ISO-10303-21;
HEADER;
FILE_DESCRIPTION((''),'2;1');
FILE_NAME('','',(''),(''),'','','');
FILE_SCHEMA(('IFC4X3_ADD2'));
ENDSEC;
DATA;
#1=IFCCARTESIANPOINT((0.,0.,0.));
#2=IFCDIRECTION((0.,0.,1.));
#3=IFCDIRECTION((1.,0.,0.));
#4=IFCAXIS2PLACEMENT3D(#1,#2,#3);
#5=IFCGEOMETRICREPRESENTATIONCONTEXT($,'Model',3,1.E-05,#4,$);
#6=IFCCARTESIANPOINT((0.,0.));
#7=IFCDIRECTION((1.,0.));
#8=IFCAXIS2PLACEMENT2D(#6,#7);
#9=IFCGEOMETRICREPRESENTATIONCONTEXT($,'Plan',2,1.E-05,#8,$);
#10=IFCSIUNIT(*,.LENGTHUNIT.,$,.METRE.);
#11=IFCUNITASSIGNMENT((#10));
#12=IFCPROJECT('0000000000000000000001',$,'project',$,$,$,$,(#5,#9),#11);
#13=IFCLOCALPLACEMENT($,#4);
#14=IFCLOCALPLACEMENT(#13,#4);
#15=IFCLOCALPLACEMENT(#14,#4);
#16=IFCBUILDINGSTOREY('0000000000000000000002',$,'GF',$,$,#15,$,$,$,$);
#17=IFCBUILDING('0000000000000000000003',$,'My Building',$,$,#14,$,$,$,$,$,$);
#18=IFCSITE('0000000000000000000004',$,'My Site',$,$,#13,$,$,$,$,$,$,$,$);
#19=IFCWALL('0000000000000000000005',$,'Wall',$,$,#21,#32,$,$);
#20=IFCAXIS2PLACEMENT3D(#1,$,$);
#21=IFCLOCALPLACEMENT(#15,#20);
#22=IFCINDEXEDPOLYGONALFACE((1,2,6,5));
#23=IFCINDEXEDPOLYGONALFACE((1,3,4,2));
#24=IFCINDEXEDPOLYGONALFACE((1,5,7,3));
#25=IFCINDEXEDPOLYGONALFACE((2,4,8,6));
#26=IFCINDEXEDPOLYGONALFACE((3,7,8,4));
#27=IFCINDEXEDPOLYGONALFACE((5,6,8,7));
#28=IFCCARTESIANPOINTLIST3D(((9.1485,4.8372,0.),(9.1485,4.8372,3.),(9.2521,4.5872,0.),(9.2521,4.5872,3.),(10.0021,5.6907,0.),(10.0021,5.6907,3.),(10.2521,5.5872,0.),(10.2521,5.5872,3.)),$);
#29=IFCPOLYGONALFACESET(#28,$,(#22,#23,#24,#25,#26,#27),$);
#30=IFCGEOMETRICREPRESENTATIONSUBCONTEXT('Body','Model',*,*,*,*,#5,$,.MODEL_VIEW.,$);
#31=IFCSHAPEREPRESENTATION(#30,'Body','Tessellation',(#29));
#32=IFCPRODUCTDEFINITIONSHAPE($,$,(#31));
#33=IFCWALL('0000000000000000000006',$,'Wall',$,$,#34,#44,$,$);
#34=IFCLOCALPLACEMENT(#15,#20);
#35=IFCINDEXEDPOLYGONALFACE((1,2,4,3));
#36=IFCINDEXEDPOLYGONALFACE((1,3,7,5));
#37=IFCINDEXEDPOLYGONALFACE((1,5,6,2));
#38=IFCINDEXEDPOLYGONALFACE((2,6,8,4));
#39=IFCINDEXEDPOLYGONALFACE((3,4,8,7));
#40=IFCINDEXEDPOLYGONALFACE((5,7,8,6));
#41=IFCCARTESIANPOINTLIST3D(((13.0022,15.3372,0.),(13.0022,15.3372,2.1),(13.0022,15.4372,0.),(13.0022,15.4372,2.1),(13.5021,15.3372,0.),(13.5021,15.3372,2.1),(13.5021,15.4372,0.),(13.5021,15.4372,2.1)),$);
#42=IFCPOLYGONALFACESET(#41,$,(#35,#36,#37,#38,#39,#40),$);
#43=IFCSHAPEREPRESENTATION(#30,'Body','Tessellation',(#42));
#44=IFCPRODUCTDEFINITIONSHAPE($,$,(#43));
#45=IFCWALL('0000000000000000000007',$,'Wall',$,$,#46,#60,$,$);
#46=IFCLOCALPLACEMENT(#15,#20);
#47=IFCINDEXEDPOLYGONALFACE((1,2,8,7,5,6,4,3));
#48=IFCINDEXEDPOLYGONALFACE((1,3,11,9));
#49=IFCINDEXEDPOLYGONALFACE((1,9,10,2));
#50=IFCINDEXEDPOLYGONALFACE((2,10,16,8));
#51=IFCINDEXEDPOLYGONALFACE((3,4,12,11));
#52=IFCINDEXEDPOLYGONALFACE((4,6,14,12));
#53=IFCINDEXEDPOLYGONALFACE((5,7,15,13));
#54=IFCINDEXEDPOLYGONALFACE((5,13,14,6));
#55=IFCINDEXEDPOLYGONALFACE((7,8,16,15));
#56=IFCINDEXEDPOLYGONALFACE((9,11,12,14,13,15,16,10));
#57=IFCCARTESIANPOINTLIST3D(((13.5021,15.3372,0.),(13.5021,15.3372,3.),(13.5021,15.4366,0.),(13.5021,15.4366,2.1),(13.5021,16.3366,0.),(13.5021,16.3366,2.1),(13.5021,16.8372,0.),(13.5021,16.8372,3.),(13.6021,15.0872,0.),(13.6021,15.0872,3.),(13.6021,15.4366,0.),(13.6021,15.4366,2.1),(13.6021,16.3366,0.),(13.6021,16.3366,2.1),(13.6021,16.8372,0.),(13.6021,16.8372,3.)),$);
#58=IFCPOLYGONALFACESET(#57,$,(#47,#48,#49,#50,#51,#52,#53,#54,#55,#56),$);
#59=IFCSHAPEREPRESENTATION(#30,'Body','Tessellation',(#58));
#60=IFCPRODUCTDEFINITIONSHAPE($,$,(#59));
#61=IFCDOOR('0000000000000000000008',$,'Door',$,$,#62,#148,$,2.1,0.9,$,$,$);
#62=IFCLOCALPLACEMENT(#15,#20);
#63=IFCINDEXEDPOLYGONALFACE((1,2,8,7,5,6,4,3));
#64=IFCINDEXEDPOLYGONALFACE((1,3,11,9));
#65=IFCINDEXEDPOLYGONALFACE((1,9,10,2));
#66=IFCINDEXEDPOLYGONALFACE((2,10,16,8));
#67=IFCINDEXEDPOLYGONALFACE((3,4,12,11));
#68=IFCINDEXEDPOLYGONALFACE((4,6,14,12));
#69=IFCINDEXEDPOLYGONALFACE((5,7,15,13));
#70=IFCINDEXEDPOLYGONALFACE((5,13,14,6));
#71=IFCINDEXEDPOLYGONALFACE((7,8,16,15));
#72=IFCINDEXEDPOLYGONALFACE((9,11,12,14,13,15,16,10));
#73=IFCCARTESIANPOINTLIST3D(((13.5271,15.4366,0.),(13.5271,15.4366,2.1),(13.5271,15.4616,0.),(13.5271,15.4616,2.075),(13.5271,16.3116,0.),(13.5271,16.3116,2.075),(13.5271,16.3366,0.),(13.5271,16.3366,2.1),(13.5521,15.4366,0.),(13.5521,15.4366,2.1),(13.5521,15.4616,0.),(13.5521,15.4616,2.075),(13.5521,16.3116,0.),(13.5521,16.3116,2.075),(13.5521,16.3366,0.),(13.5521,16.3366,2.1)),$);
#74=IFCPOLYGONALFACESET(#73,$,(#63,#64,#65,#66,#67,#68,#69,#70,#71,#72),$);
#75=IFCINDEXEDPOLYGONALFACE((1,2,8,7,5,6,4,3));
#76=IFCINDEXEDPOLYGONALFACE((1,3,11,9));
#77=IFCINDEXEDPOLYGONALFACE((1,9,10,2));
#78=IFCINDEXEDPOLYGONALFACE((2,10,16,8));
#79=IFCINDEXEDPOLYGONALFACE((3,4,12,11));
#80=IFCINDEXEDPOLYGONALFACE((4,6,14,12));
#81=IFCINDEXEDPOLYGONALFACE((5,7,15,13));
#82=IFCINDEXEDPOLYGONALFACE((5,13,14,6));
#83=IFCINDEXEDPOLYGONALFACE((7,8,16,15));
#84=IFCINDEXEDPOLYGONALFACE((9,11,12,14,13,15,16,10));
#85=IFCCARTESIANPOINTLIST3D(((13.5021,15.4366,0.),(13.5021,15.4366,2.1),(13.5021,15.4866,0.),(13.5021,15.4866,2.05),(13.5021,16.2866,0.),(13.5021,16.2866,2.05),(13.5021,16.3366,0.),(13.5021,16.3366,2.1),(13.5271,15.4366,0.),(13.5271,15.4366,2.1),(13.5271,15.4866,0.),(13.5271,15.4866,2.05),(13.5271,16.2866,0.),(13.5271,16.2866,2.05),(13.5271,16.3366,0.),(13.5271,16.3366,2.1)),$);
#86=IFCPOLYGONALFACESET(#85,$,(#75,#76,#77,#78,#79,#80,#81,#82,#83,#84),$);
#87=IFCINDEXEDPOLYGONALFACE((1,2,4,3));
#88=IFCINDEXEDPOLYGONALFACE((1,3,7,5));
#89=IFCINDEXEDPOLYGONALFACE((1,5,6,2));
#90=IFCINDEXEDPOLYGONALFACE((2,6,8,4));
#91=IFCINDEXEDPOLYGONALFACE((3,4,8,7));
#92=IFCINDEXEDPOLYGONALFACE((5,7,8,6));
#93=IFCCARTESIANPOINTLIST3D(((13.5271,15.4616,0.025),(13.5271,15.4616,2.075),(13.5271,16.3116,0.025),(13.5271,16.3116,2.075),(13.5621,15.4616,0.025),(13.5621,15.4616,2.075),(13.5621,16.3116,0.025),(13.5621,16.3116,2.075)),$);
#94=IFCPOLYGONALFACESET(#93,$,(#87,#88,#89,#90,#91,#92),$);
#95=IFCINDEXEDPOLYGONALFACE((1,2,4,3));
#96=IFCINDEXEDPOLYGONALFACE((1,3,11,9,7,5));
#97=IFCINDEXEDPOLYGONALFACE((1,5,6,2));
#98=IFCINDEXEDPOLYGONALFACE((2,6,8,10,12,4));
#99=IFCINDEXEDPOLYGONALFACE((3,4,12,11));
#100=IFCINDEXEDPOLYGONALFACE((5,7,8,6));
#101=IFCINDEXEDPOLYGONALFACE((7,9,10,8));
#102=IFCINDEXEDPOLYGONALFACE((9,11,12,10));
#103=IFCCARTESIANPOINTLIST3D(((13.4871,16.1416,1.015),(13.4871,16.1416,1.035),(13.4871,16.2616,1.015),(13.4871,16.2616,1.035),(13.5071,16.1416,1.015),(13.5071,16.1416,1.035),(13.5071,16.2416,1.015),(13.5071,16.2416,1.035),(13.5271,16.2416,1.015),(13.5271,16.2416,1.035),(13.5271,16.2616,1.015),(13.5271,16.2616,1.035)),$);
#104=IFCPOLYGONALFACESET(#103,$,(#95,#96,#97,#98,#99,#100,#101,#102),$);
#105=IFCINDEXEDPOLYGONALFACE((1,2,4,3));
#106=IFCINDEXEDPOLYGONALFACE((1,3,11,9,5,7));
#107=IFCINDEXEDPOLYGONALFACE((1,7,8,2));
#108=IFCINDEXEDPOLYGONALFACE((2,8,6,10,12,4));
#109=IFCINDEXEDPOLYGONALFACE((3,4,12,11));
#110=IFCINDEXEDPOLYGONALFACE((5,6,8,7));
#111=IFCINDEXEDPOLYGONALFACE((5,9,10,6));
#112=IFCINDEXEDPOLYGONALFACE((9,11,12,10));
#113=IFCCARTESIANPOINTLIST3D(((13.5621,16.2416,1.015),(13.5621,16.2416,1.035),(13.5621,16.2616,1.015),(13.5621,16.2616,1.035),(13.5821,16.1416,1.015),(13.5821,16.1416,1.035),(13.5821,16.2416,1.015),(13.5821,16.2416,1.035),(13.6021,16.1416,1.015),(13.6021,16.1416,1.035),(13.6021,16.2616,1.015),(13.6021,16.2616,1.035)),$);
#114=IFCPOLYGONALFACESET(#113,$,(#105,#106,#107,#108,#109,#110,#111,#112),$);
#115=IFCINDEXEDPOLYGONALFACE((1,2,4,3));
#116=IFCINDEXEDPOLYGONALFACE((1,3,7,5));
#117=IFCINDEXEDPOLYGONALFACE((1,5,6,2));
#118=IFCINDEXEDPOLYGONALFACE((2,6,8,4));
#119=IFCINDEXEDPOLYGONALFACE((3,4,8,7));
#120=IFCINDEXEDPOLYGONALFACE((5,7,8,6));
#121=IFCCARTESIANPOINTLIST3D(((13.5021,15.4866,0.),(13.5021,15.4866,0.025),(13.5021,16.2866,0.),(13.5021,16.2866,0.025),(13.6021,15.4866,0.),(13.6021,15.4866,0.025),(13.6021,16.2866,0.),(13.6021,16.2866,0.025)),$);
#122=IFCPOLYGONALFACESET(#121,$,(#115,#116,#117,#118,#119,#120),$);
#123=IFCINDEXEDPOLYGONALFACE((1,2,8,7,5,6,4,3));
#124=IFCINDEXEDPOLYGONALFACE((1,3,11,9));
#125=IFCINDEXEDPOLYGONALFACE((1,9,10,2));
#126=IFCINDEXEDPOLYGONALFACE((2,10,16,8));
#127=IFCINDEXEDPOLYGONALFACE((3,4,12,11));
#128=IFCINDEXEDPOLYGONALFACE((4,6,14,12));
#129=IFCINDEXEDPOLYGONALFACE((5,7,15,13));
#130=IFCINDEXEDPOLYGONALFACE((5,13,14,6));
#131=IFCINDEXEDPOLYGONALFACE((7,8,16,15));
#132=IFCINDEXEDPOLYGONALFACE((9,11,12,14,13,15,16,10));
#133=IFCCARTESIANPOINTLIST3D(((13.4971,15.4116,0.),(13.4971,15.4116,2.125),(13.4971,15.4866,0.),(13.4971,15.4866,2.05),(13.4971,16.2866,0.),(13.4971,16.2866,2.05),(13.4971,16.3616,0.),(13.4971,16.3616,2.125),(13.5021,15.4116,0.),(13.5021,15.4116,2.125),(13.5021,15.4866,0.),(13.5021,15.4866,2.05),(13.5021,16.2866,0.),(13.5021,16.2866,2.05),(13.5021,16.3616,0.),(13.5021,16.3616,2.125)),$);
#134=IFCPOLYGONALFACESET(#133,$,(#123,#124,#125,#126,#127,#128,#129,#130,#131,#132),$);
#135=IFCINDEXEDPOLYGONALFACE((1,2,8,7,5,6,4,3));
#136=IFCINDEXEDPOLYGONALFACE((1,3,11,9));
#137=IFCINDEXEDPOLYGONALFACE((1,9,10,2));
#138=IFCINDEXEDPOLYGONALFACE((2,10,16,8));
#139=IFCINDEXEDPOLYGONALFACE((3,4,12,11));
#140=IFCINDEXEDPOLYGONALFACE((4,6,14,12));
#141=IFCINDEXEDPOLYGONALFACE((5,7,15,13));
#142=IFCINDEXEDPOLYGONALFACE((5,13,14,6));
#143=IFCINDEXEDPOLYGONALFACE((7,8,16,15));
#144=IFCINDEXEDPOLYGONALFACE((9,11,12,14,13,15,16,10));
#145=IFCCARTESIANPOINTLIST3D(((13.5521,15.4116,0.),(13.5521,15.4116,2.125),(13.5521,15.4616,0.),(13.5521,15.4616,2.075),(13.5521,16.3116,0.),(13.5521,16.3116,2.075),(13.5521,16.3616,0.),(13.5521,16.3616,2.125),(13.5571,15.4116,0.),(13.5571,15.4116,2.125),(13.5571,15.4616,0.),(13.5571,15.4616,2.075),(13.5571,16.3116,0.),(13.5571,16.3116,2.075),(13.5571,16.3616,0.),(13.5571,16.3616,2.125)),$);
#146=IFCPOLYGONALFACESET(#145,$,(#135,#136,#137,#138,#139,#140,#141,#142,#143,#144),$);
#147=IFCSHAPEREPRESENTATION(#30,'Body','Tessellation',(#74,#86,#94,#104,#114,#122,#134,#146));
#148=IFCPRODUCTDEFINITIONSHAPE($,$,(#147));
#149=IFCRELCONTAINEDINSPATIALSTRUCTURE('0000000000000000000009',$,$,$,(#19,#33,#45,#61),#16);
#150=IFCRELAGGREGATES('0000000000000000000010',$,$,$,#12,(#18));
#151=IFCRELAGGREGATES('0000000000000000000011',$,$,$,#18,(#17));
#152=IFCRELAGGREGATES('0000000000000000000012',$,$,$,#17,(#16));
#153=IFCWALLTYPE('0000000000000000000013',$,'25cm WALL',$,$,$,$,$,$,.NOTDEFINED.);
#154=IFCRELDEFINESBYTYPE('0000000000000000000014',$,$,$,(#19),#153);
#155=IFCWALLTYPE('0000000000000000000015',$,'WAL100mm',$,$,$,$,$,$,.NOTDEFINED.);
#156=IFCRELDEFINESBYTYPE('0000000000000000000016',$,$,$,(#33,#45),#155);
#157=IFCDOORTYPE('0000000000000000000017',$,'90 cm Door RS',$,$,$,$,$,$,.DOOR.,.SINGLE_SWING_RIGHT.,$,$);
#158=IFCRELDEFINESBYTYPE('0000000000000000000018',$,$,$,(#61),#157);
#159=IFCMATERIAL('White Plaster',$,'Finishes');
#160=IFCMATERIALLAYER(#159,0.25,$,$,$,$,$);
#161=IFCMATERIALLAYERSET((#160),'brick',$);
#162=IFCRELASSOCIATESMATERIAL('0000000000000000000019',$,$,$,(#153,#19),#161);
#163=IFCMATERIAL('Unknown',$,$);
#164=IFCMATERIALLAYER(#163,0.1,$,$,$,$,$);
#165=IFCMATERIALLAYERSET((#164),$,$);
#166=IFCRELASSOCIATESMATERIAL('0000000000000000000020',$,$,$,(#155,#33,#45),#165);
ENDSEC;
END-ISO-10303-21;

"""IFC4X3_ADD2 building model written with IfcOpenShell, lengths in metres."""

from ifc_helpers import new_model, entity, si_unit, frame, origin_with_axes, origin_2d_with_axis, place, context, subcontext, project, spatial, line, indexed_curve, outline, extrude, shape, source, transform, mapped, material, layer, layer_set, layer_usage, type_object, type_shapes, element, fill, save


model = new_model("IFC4X3_ADD2")

# Units and contexts
model_context = context("Model", 3, precision=1e-05, world=origin_with_axes())
plan_context = context("Plan", 2, precision=1e-05, world=origin_2d_with_axis())
body_context_1 = subcontext(model_context, "Body", "Model", "MODEL_VIEW")
body_context_2 = subcontext(plan_context, "Body", "Plan", "PLAN_VIEW")
ifc_project = project(units=[si_unit("LENGTHUNIT", "METRE")], contexts=[model_context, plan_context])

# Site, building, storey
site_placement = place(None, origin_with_axes())
site = spatial("IfcSite", under=ifc_project, at=site_placement, Name="My Site")
building_placement = place(site_placement, origin_with_axes())
building = spatial("IfcBuilding", under=site, at=building_placement, Name="My Building")
storey_placement = place(building_placement, origin_with_axes())
storey = spatial("IfcBuildingStorey", under=building, at=storey_placement, Name="GF")

# Shared definitions
ifc_material_1 = material(Name="White Plaster", Category="Finishes")

# Shared definitions
ifc_layer_1 = layer(ifc_material_1, 0.25)
ifc_layer_set_1 = layer_set([ifc_layer_1], Name="brick")
wall_type_1 = type_object("IfcWallType", Name="25cm WALL", PredefinedType="NOTDEFINED", material=ifc_layer_set_1)

# Walls
ifc_layer_usage_1 = layer_usage(ifc_layer_set_1, "AXIS2", "POSITIVE", 0.0)
wall_1_placement = place(storey_placement, frame((10.0021, 5.6907, 0.0), z_axis=(0.0, 0.0, 1.0), x_axis=(-0.707107, -0.707107, 0.0)))
element("IfcWall", 1, at=wall_1_placement, inside=storey, type_object=wall_type_1, material=ifc_layer_usage_1, Name="Wall", context=body_context_1, shape_type="SweptSolid", body=[
    extrude(outline(indexed_curve([(0.0, 0.0), (-0.1036, 0.25), (1.3107, 0.25), (1.2071, 0.0)], segments=[line(1, 2, 3, 4, 1)])), origin_with_axes(), (0.0, 0.0, 1.0), 3.0),
])
ifc_material_2 = material(Name="Unknown")
ifc_layer_2 = layer(ifc_material_2, 0.1)
ifc_layer_set_2 = layer_set([ifc_layer_2])
ifc_layer_usage_2 = layer_usage(ifc_layer_set_2, "AXIS2", "POSITIVE", 0.0)
wall_type_2 = type_object("IfcWallType", Name="WAL100mm", PredefinedType="NOTDEFINED", material=ifc_layer_set_2)
wall_2_placement = place(storey_placement, frame((13.0022, 15.3372, 0.0), z_axis=(0.0, 0.0, 1.0), x_axis=(1.0, 0.0, 0.0)))
element("IfcWall", 2, at=wall_2_placement, inside=storey, type_object=wall_type_2, material=ifc_layer_usage_2, Name="Wall", context=body_context_1, shape_type="SweptSolid", body=[
    extrude(outline(indexed_curve([(0.0, 0.0), (0.0, 0.1), (0.4999, 0.1), (0.4999, 0.0)], segments=[line(1, 2, 3, 4, 1)])), origin_with_axes(), (0.0, 0.0, 1.0), 2.1),
])

# Wall, opening, door
ifc_layer_usage_3 = layer_usage(ifc_layer_set_2, "AXIS2", "POSITIVE", 0.0)
wall_3_placement = place(storey_placement, frame((13.5021, 16.8372, 0.0), z_axis=(0.0, 0.0, 1.0), x_axis=(0.0, -1.0, 0.0)))
wall_3 = element("IfcWall", 3, at=wall_3_placement, inside=storey, type_object=wall_type_2, material=ifc_layer_usage_3, Name="Wall", context=body_context_1, shape_type="SweptSolid", body=[
    extrude(outline(indexed_curve([(0.0, 0.0), (0.0, 0.1), (1.75, 0.1), (1.5, 0.0)], segments=[line(1, 2, 3, 4, 1)])), origin_with_axes(), (0.0, 0.0, 1.0), 3.0),
])
shared_shape_1 = source(origin_with_axes(), body_context_1, "Body", "SweptSolid", [
    extrude(outline(indexed_curve([(0.0, 0.0), (0.9, 0.0), (0.9, 2.1), (0.0, 2.1)], segments=[line(1, 2, 3, 4, 1)])), frame((0.0, -0.6, 0.0), z_axis=(0.0, -1.0, 0.0), x_axis=(1.0, 0.0, 0.0)), (0.0, 0.0, -1.0), 1.2),
])
opening_1_placement = place(wall_3_placement, frame((0.5006, 0.0, 0.0), z_axis=(0.0, 0.0, 1.0), x_axis=(1.0, 0.0, 0.0)))
opening_1 = element("IfcOpeningElement", 4, at=opening_1_placement, cuts=wall_3, PredefinedType="OPENING", context=body_context_1, shape_type="MappedRepresentation", body=[
    mapped(shared_shape_1, transform((0.0, 0.0, 0.0), x_axis=(1.0, 0.0, 0.0), y_axis=(0.0, 1.0, 0.0), z_axis=(0.0, 0.0, 1.0), scale=1.0)),
])
door_type_1 = type_object("IfcDoorType", Name="90 cm Door RS", OperationType="SINGLE_SWING_RIGHT", PredefinedType="DOOR")
shared_shape_2 = source(origin_with_axes(), body_context_1, "Body", "SweptSolid", [
    extrude(outline(indexed_curve([(0.0, 0.0), (0.0, 2.1), (0.9, 2.1), (0.9, 0.0), (0.875, 0.0), (0.875, 2.075), (0.025, 2.075), (0.025, 0.0)], segments=[line(1, 2, 3, 4, 5, 6, 7, 8, 1)])), frame((0.0, 0.025, 0.0), z_axis=(0.0, -1.0, 0.0), x_axis=(1.0, 0.0, 0.0)), (0.0, 0.0, -1.0), 0.025),
    extrude(outline(indexed_curve([(0.0, 0.0), (0.0, 2.1), (0.9, 2.1), (0.9, 0.0), (0.85, 0.0), (0.85, 2.05), (0.05, 2.05), (0.05, 0.0)], segments=[line(1, 2, 3, 4, 5, 6, 7, 8, 1)])), frame((0.0, 0.0, 0.0), z_axis=(0.0, -1.0, 0.0), x_axis=(1.0, 0.0, 0.0)), (0.0, 0.0, -1.0), 0.025),
    extrude(outline(indexed_curve([(0.0, 0.0), (0.85, 0.0), (0.85, 0.035), (0.0, 0.035)], segments=[line(1, 2, 3, 4, 1)])), frame((0.025, 0.025, 0.025), z_axis=(0.0, 0.0, 1.0), x_axis=(1.0, 0.0, 0.0)), (0.0, 0.0, 1.0), 2.05),
    extrude(outline(indexed_curve([(0.0, 0.0), (0.0, -0.04), (0.12, -0.04), (0.12, -0.02), (0.02, -0.02), (0.02, 0.0)], segments=[line(1, 2, 3, 4, 5, 6, 1)])), frame((0.075, 0.025, 1.015), z_axis=(0.0, 0.0, 1.0), x_axis=(1.0, 0.0, 0.0)), (0.0, 0.0, 1.0), 0.02),
    extrude(outline(indexed_curve([(0.0, 0.0), (0.0, 0.04), (0.12, 0.04), (0.12, 0.02), (0.02, 0.02), (0.02, 0.0)], segments=[line(1, 2, 3, 4, 5, 6, 1)])), frame((0.075, 0.06, 1.015), z_axis=(0.0, 0.0, 1.0), x_axis=(1.0, 0.0, 0.0)), (0.0, 0.0, 1.0), 0.02),
    extrude(outline(indexed_curve([(0.0, 0.0), (0.8, 0.0), (0.8, 0.1), (0.0, 0.1)], segments=[line(1, 2, 3, 4, 1)])), frame((0.05, 0.0, 0.0), z_axis=(0.0, 0.0, 1.0), x_axis=(1.0, 0.0, 0.0)), (0.0, 0.0, 1.0), 0.025),
    extrude(outline(indexed_curve([(0.0, 0.0), (0.0, 2.125), (0.95, 2.125), (0.95, 0.0), (0.875, 0.0), (0.875, 2.05), (0.075, 2.05), (0.075, 0.0)], segments=[line(1, 2, 3, 4, 5, 6, 7, 8, 1)])), frame((-0.025, -0.005, 0.0), z_axis=(0.0, -1.0, 0.0), x_axis=(1.0, 0.0, 0.0)), (0.0, 0.0, -1.0), 0.005),
    extrude(outline(indexed_curve([(0.0, 0.0), (0.0, 2.125), (0.95, 2.125), (0.95, 0.0), (0.9, 0.0), (0.9, 2.075), (0.05, 2.075), (0.05, 0.0)], segments=[line(1, 2, 3, 4, 5, 6, 7, 8, 1)])), frame((-0.025, 0.05, 0.0), z_axis=(0.0, -1.0, 0.0), x_axis=(1.0, 0.0, 0.0)), (0.0, 0.0, -1.0), 0.005),
])
shared_shape_3 = source(origin_with_axes(), body_context_2, "Body", "Curve2D", [
    entity("IfcIndexedPolyCurve", entity("IfcCartesianPointList2D", [[0.0, 0.0], [0.0, 0.05], [0.025, 0.05], [0.025, 0.025], [0.05, 0.025], [0.05, 0.0]]), [entity("IfcLineIndex", [1, 2, 3, 4, 5, 6, 1])]),
    entity("IfcIndexedPolyCurve", entity("IfcCartesianPointList2D", [[0.9, 0.0], [0.9, 0.05], [0.875, 0.05], [0.875, 0.025], [0.85, 0.025], [0.85, 0.0]]), [entity("IfcLineIndex", [1, 2, 3, 4, 5, 6, 1])]),
    entity("IfcTrimmedCurve", entity("IfcEllipse", entity("IfcAxis2Placement2D", entity("IfcCartesianPoint", [0.84, 0.05]), entity("IfcDirection", [1.0, 0.0])), 0.815, 0.85), [entity("IfcCartesianPoint", [0.84, 0.9])], [entity("IfcCartesianPoint", [0.025, 0.05])], True, "CARTESIAN"),
    entity("IfcIndexedPolyCurve", entity("IfcCartesianPointList2D", [[0.875, 0.05], [0.84, 0.05], [0.84, 0.9], [0.875, 0.9]]), [entity("IfcLineIndex", [1, 2, 3, 4, 1])]),
])
type_shapes(door_type_1, [shared_shape_2, shared_shape_3])
door_1_placement = place(opening_1_placement, frame((0.0, 0.0, 0.0), z_axis=(0.0, 0.0, 1.0), x_axis=(1.0, 0.0, 0.0)))
door_1 = element("IfcDoor", 5, at=door_1_placement, inside=storey, type_object=door_type_1, Name="Door", OverallHeight=2.1, OverallWidth=0.9, shapes=[
    shape(body_context_1, "Body", "MappedRepresentation", [mapped(shared_shape_2, transform((0.0, 0.0, 0.0), x_axis=(1.0, 0.0, 0.0), y_axis=(0.0, 1.0, 0.0), z_axis=(0.0, 0.0, 1.0), scale=1.0))]),
    shape(body_context_2, "Body", "MappedRepresentation", [mapped(shared_shape_3, transform((0.0, 0.0, 0.0), x_axis=(1.0, 0.0, 0.0), y_axis=(0.0, 1.0, 0.0), z_axis=(0.0, 0.0, 1.0), scale=1.0))]),
])
fill(opening_1, door_1)

save(model, "model.ifc")
